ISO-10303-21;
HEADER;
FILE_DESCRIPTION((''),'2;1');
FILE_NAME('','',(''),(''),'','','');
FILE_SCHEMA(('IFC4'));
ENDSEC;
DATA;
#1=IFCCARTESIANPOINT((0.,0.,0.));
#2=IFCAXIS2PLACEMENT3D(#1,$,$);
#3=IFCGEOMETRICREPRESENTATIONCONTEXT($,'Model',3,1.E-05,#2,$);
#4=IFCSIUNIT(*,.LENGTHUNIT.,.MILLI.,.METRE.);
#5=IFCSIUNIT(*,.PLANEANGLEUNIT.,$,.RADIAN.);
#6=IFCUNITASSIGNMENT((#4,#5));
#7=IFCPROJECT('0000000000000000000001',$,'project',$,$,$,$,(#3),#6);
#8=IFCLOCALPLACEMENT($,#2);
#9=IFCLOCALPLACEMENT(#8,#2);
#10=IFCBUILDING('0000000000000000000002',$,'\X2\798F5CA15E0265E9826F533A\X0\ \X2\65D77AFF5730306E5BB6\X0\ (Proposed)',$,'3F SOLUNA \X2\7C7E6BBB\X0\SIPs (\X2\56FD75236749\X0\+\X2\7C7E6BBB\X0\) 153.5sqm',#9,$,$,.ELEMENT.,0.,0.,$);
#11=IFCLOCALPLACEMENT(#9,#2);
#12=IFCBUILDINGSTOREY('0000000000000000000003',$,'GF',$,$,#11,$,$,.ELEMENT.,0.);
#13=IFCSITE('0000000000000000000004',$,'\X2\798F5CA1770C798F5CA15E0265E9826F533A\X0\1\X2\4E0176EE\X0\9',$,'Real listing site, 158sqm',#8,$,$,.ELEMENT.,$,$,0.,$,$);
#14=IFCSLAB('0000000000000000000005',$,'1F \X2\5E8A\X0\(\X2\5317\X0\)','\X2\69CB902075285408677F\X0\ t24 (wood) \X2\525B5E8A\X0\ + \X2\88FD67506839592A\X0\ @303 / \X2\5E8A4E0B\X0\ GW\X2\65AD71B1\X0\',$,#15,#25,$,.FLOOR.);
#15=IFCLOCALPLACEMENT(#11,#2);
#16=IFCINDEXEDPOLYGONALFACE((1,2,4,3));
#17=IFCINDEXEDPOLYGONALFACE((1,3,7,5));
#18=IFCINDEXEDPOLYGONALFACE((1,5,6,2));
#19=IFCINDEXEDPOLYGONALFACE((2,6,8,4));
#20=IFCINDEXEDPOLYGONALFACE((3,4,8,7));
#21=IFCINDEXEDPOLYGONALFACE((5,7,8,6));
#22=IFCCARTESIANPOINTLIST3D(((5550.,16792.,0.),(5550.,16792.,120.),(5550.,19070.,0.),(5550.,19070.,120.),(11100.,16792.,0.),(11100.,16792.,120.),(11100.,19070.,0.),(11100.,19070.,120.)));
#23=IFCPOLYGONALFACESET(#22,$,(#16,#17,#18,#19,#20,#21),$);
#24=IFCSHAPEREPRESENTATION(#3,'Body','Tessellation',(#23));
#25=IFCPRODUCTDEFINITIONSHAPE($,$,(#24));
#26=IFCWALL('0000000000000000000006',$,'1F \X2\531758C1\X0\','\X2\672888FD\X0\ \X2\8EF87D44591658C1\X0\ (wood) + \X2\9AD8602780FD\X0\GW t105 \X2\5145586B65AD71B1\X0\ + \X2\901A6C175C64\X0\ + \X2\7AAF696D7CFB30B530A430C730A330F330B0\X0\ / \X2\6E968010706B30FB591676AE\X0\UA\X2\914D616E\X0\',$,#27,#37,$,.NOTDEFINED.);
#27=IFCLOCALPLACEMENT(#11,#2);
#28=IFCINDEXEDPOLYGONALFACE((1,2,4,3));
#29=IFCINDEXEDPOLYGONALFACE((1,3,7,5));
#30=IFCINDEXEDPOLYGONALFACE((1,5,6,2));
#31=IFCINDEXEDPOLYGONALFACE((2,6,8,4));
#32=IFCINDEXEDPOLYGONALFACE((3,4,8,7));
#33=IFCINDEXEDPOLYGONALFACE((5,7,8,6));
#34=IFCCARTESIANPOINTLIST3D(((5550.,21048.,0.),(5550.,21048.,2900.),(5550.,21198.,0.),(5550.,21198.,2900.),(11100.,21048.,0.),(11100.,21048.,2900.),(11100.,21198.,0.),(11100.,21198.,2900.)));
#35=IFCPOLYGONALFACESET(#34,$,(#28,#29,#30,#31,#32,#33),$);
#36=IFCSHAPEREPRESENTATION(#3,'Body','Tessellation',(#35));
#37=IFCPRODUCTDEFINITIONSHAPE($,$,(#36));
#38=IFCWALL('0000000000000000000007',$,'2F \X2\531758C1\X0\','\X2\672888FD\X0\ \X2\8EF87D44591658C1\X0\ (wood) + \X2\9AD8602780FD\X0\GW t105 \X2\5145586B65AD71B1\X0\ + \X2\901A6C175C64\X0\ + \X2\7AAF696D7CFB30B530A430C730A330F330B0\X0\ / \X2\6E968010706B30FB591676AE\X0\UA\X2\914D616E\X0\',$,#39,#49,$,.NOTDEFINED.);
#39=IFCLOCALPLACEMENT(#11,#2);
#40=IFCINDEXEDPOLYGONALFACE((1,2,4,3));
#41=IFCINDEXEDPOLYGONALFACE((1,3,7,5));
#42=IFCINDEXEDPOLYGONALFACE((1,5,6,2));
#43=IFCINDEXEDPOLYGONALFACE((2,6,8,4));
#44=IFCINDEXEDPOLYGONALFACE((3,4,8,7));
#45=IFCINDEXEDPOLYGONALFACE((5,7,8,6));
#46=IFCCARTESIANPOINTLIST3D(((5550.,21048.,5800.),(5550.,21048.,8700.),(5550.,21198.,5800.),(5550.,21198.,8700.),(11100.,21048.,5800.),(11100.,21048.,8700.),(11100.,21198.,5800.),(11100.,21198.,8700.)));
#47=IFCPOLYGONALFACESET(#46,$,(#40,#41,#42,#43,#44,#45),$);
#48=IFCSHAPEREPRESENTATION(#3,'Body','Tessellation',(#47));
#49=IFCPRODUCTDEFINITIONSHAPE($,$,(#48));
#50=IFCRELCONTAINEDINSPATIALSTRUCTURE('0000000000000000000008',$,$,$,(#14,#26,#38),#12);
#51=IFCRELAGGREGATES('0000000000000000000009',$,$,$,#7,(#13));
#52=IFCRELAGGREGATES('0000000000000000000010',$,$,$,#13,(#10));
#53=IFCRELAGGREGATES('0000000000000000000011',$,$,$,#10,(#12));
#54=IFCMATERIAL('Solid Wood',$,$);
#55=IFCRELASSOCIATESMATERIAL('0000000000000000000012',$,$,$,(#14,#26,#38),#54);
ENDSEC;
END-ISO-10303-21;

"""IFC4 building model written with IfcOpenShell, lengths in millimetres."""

from ifc_helpers import new_model, si_unit, frame, frame_2d, origin, place, context, project, spatial, rectangle, extrude, material, element, save


model = new_model("IFC4")

# Units and contexts
model_context = context("Model", 3, precision=1e-05, world=origin())
ifc_project = project(units=[si_unit("LENGTHUNIT", "METRE", prefix="MILLI"), si_unit("PLANEANGLEUNIT", "RADIAN")], contexts=[model_context])

# Site, building, storey
site_placement = place(None, origin())
site = spatial("IfcSite", under=ifc_project, at=site_placement, Name="福岡県福岡市早良区1丁目9", ObjectType="Real listing site, 158sqm", CompositionType="ELEMENT", RefElevation=0.0)
building_placement = place(site_placement, origin())
building = spatial("IfcBuilding", under=site, at=building_placement, Name="福岡市早良区 旗竿地の家 (Proposed)", ObjectType="3F SOLUNA 籾殻SIPs (国産杉+籾殻) 153.5sqm", CompositionType="ELEMENT", ElevationOfRefHeight=0.0, ElevationOfTerrain=0.0)
storey_placement = place(building_placement, origin())
storey = spatial("IfcBuildingStorey", under=building, at=storey_placement, Name="GF", CompositionType="ELEMENT", Elevation=0.0)

# Slab
ifc_material_1 = material(Name="Solid Wood")
slab_1_placement = place(storey_placement, frame((2775.0, 8396.0, 0.0)))
element("IfcSlab", 1, at=slab_1_placement, inside=storey, material=ifc_material_1, Name="1F 床(北)", Description="構造用合板 t24 (wood) 剛床 + 製材根太 @303 / 床下 GW断熱", PredefinedType="FLOOR", context=model_context, shape_type="SweptSolid", body=[
    extrude(rectangle(XDim=5550.0, YDim=2278.0, at=frame_2d((2775.0, 1139.0))), frame((2775.0, 8396.0, 0.0)), (0.0, 0.0, 1.0), 120.0),
])

# Wall
wall_1_placement = place(storey_placement, frame((2775.0, 10524.0, 0.0)))
element("IfcWall", 2, at=wall_1_placement, inside=storey, material=ifc_material_1, Name="1F 北壁", Description="木製 軸組外壁 (wood) + 高性能GW t105 充填断熱 + 通気層 + 窯業系サイディング / 準耐火・外皮UA配慮", PredefinedType="NOTDEFINED", context=model_context, shape_type="SweptSolid", body=[
    extrude(rectangle(XDim=5550.0, YDim=150.0, at=frame_2d((2775.0, 75.0))), frame((2775.0, 10524.0, 0.0)), (0.0, 0.0, 1.0), 2900.0),
])

# Wall
wall_2_placement = place(storey_placement, frame((2775.0, 10524.0, 2900.0)))
element("IfcWall", 3, at=wall_2_placement, inside=storey, material=ifc_material_1, Name="2F 北壁", Description="木製 軸組外壁 (wood) + 高性能GW t105 充填断熱 + 通気層 + 窯業系サイディング / 準耐火・外皮UA配慮", PredefinedType="NOTDEFINED", context=model_context, shape_type="SweptSolid", body=[
    extrude(rectangle(XDim=5550.0, YDim=150.0, at=frame_2d((2775.0, 75.0))), frame((2775.0, 10524.0, 2900.0)), (0.0, 0.0, 1.0), 2900.0),
])

save(model, "model.ifc")
